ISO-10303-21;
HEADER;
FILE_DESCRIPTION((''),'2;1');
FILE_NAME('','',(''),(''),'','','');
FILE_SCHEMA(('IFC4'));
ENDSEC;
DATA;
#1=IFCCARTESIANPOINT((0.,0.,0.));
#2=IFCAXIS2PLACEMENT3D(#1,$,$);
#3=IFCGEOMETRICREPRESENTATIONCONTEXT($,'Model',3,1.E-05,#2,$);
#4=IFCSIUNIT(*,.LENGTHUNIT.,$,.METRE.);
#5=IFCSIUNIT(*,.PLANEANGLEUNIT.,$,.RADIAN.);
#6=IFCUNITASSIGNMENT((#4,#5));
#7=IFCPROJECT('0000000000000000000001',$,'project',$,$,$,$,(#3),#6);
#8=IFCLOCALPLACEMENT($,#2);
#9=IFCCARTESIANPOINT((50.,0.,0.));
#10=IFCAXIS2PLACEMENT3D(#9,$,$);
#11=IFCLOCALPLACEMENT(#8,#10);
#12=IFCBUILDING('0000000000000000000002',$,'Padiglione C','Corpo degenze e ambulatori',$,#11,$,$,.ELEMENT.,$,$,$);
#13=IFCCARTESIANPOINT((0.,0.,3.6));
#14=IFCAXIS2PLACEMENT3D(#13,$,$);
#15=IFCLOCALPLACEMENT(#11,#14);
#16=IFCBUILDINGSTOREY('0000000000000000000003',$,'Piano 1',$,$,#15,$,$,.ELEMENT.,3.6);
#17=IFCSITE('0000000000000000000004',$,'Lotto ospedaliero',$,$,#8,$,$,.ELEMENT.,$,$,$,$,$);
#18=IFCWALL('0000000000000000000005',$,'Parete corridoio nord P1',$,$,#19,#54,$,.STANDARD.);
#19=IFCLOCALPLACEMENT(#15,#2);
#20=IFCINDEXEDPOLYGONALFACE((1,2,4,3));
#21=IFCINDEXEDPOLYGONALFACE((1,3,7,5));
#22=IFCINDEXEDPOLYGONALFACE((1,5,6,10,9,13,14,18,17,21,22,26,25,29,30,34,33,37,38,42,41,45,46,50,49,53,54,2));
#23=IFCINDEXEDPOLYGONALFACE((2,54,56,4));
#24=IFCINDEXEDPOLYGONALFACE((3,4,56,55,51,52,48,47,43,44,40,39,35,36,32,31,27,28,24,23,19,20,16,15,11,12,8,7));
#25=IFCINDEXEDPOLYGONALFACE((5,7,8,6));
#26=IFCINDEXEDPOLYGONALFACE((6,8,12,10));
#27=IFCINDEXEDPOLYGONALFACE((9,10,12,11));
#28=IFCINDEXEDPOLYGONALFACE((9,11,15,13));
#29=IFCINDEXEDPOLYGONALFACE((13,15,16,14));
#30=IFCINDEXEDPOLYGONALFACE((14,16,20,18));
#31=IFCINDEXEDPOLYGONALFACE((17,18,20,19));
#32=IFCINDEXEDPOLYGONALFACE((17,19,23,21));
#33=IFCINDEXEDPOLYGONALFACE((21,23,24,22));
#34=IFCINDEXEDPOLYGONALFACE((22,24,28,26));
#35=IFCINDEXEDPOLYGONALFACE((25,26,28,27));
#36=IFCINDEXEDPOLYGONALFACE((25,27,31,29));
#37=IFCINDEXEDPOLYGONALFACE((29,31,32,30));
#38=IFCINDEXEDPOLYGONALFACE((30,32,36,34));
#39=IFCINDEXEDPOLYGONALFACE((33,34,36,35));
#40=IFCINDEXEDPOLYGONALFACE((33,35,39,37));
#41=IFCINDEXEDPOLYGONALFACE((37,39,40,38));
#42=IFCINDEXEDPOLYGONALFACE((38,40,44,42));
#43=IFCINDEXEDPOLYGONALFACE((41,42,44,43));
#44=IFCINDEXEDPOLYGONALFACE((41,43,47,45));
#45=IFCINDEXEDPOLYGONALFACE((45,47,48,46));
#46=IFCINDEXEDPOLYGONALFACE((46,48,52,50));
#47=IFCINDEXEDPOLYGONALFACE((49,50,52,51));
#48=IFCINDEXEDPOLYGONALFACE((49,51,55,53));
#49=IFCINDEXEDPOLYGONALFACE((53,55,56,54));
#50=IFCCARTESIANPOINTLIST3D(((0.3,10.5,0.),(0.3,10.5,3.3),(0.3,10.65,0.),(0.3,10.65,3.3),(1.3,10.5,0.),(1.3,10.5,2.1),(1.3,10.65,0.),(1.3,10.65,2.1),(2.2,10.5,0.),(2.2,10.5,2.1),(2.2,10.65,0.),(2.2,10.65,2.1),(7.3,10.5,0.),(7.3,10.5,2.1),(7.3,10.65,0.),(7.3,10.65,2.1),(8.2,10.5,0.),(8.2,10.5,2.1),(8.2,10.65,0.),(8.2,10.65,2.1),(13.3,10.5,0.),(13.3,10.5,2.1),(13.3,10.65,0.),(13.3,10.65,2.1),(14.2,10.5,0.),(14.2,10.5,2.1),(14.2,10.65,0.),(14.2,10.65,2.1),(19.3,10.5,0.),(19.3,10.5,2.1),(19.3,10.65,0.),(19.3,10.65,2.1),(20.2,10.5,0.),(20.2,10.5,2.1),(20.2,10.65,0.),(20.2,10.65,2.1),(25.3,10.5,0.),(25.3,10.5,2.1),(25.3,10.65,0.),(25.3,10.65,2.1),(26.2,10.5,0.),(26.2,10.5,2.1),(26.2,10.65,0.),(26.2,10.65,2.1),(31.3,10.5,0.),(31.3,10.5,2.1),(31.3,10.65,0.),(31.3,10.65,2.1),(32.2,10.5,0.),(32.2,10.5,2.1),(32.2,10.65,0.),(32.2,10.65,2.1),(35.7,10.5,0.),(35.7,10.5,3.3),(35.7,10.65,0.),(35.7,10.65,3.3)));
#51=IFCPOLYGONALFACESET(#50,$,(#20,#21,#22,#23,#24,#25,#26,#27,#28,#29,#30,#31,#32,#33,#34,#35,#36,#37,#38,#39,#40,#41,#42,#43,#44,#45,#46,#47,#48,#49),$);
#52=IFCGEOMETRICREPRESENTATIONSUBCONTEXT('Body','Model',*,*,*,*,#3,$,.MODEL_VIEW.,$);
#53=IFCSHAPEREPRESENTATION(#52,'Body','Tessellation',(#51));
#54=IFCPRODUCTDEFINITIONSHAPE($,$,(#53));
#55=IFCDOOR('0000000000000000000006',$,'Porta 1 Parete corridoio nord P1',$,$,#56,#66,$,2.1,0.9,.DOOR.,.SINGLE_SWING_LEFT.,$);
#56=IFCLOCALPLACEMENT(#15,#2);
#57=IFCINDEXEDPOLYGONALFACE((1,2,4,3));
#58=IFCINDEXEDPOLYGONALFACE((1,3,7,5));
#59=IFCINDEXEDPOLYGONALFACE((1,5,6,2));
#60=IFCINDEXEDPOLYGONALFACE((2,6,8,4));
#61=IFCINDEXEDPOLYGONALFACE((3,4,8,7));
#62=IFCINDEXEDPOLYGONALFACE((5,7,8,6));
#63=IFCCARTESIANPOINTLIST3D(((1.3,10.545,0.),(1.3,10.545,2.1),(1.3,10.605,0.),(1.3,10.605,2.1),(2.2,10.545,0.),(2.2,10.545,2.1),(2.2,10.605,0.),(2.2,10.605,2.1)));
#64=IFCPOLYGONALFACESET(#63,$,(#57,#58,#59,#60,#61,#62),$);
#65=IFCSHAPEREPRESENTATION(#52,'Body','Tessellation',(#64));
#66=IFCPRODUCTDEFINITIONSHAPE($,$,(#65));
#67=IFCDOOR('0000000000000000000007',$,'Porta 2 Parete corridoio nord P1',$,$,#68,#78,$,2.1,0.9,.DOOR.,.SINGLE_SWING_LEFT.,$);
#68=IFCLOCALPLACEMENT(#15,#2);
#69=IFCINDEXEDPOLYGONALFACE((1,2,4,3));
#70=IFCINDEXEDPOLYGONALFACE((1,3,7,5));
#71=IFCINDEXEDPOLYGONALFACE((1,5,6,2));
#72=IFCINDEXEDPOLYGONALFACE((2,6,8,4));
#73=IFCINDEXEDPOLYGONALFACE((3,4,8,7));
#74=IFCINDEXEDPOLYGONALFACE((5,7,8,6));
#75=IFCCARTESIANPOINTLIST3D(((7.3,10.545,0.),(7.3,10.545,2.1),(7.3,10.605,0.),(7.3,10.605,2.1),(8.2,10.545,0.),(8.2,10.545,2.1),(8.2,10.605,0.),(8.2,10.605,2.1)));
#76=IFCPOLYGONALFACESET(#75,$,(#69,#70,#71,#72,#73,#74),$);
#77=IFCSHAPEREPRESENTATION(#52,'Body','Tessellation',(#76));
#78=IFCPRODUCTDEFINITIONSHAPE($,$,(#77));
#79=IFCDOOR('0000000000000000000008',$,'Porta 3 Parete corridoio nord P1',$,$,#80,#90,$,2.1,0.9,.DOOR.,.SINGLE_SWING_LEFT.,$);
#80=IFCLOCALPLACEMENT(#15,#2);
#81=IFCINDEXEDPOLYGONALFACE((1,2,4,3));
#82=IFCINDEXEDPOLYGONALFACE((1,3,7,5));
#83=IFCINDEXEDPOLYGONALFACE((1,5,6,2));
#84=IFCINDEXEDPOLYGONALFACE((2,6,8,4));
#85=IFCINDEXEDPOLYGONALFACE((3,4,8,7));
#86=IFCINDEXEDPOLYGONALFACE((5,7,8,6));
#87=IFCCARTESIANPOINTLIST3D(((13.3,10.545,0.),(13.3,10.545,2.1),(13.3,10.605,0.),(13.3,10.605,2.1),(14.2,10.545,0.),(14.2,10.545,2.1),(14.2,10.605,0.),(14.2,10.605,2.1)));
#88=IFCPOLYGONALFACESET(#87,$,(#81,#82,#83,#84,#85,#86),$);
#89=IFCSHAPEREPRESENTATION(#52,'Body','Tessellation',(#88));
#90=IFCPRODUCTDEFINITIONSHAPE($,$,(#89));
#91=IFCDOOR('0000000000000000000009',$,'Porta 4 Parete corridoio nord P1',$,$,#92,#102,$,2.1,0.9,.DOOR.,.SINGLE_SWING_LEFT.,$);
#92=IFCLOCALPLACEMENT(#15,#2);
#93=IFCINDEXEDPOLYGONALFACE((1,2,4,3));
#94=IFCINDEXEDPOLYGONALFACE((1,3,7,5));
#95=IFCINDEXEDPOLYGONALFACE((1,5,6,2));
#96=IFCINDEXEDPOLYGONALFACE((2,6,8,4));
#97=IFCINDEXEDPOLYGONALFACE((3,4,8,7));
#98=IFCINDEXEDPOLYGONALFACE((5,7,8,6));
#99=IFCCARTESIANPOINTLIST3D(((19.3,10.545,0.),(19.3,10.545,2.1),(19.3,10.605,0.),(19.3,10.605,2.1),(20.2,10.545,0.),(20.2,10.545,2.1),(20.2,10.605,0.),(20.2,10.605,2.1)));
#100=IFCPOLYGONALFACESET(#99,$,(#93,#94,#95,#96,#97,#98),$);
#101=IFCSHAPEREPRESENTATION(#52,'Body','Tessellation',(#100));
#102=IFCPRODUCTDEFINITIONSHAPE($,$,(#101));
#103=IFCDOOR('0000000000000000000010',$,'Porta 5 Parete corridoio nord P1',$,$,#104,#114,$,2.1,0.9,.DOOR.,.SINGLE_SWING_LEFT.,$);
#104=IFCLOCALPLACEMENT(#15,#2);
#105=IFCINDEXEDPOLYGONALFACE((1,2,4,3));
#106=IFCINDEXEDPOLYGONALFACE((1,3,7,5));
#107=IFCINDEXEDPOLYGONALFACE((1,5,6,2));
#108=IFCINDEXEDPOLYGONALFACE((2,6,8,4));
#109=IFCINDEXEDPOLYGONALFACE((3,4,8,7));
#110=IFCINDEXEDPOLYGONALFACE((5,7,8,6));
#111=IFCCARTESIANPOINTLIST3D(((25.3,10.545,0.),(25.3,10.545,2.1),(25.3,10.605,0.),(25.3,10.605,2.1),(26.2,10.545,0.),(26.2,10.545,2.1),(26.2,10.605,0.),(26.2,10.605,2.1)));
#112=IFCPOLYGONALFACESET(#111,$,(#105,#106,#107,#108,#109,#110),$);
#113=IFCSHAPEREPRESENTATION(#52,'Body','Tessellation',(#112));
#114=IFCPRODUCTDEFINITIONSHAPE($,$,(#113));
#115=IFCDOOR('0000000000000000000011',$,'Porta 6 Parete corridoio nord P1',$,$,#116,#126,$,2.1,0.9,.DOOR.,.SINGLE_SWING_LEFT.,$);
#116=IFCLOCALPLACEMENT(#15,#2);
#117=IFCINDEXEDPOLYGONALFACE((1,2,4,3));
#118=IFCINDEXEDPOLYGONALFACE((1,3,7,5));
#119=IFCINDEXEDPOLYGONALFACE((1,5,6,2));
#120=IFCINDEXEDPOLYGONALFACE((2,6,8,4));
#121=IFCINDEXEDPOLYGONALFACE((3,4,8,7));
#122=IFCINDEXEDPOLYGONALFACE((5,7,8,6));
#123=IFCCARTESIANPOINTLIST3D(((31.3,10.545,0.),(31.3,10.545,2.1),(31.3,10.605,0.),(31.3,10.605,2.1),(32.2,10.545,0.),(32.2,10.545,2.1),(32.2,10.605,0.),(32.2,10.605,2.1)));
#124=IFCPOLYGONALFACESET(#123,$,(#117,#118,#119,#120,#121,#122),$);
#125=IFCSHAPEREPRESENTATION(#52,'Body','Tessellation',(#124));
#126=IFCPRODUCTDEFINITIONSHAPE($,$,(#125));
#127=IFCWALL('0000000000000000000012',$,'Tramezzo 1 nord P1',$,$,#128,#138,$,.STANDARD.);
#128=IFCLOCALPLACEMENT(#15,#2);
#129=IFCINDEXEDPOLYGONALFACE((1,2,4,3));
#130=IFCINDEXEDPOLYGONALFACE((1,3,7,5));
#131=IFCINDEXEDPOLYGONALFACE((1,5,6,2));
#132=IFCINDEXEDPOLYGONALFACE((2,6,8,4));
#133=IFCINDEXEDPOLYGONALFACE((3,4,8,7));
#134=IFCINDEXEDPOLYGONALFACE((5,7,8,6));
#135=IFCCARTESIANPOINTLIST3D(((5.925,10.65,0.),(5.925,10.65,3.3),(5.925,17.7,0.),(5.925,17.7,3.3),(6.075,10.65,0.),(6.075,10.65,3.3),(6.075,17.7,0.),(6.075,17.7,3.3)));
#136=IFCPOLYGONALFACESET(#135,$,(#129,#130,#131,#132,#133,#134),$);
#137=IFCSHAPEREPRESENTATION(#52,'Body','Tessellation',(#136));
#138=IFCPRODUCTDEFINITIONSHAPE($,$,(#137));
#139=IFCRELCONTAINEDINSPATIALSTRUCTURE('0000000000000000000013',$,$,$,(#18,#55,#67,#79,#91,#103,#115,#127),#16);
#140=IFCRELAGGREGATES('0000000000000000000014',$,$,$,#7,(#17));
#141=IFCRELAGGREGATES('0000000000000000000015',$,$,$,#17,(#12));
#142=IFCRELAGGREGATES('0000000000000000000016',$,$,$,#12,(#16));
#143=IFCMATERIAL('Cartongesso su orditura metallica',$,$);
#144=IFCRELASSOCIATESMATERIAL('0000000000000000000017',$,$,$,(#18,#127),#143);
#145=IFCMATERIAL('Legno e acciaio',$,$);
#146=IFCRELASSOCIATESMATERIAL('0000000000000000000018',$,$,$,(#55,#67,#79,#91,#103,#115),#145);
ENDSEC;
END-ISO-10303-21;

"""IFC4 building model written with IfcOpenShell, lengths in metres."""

from ifc_helpers import new_model, si_unit, frame, frame_2d, origin, place, context, subcontext, project, spatial, rectangle, extrude, material, element, fill, save


model = new_model("IFC4")

# Units and contexts
model_context = context("Model", 3, precision=1e-05, world=origin())
body_context = subcontext(model_context, "Body", "Model", "MODEL_VIEW")
ifc_project = project(units=[si_unit("LENGTHUNIT", "METRE"), si_unit("PLANEANGLEUNIT", "RADIAN")], contexts=[model_context])

# Site, building, storey
site_placement = place(None, origin())
site = spatial("IfcSite", under=ifc_project, at=site_placement, Name="Lotto ospedaliero", CompositionType="ELEMENT")
building_placement = place(site_placement, frame((50.0, 0.0, 0.0)))
building = spatial("IfcBuilding", under=site, at=building_placement, Name="Padiglione C", Description="Corpo degenze e ambulatori", CompositionType="ELEMENT")
storey_placement = place(building_placement, frame((0.0, 0.0, 3.6)))
storey = spatial("IfcBuildingStorey", under=building, at=storey_placement, Name="Piano 1", CompositionType="ELEMENT", Elevation=3.6)

# Wall, openings, doors
ifc_material_1 = material(Name="Cartongesso su orditura metallica")
ifc_material_2 = material(Name="Legno e acciaio")
wall_1_placement = place(storey_placement, frame((0.3, 10.5, 0.0)))
wall_1 = element("IfcWall", 1, at=wall_1_placement, inside=storey, material=ifc_material_1, Name="Parete corridoio nord P1", PredefinedType="STANDARD", context=body_context, shape_type="SweptSolid", body=[
    extrude(rectangle(XDim=35.4, YDim=0.15, at=frame_2d((17.7, 0.075))), origin(), (0.0, 0.0, 1.0), 3.3),
])
opening_1_placement = place(wall_1_placement, frame((1.0, -0.1, 0.0)))
opening_1 = element("IfcOpeningElement", 2, at=opening_1_placement, cuts=wall_1, PredefinedType="OPENING", context=body_context, shape_type="SweptSolid", body=[
    extrude(rectangle(XDim=0.9, YDim=0.35, at=frame_2d((0.45, 0.175))), origin(), (0.0, 0.0, 1.0), 2.1),
])
opening_2_placement = place(wall_1_placement, frame((7.0, -0.1, 0.0)))
opening_2 = element("IfcOpeningElement", 3, at=opening_2_placement, cuts=wall_1, PredefinedType="OPENING", context=body_context, shape_type="SweptSolid", body=[
    extrude(rectangle(XDim=0.9, YDim=0.35, at=frame_2d((0.45, 0.175))), origin(), (0.0, 0.0, 1.0), 2.1),
])
opening_3_placement = place(wall_1_placement, frame((13.0, -0.1, 0.0)))
opening_3 = element("IfcOpeningElement", 4, at=opening_3_placement, cuts=wall_1, PredefinedType="OPENING", context=body_context, shape_type="SweptSolid", body=[
    extrude(rectangle(XDim=0.9, YDim=0.35, at=frame_2d((0.45, 0.175))), origin(), (0.0, 0.0, 1.0), 2.1),
])
opening_4_placement = place(wall_1_placement, frame((19.0, -0.1, 0.0)))
opening_4 = element("IfcOpeningElement", 5, at=opening_4_placement, cuts=wall_1, PredefinedType="OPENING", context=body_context, shape_type="SweptSolid", body=[
    extrude(rectangle(XDim=0.9, YDim=0.35, at=frame_2d((0.45, 0.175))), origin(), (0.0, 0.0, 1.0), 2.1),
])
opening_5_placement = place(wall_1_placement, frame((25.0, -0.1, 0.0)))
opening_5 = element("IfcOpeningElement", 6, at=opening_5_placement, cuts=wall_1, PredefinedType="OPENING", context=body_context, shape_type="SweptSolid", body=[
    extrude(rectangle(XDim=0.9, YDim=0.35, at=frame_2d((0.45, 0.175))), origin(), (0.0, 0.0, 1.0), 2.1),
])
opening_6_placement = place(wall_1_placement, frame((31.0, -0.1, 0.0)))
opening_6 = element("IfcOpeningElement", 7, at=opening_6_placement, cuts=wall_1, PredefinedType="OPENING", context=body_context, shape_type="SweptSolid", body=[
    extrude(rectangle(XDim=0.9, YDim=0.35, at=frame_2d((0.45, 0.175))), origin(), (0.0, 0.0, 1.0), 2.1),
])
door_1_placement = place(wall_1_placement, frame((1.0, 0.045, 0.0)))
door_1 = element("IfcDoor", 8, at=door_1_placement, inside=storey, material=ifc_material_2, Name="Porta 1 Parete corridoio nord P1", OperationType="SINGLE_SWING_LEFT", OverallHeight=2.1, OverallWidth=0.9, PredefinedType="DOOR", context=body_context, shape_type="SweptSolid", body=[
    extrude(rectangle(XDim=0.9, YDim=0.06, at=frame_2d((0.45, 0.03))), origin(), (0.0, 0.0, 1.0), 2.1),
])
fill(opening_1, door_1)
door_2_placement = place(wall_1_placement, frame((7.0, 0.045, 0.0)))
door_2 = element("IfcDoor", 9, at=door_2_placement, inside=storey, material=ifc_material_2, Name="Porta 2 Parete corridoio nord P1", OperationType="SINGLE_SWING_LEFT", OverallHeight=2.1, OverallWidth=0.9, PredefinedType="DOOR", context=body_context, shape_type="SweptSolid", body=[
    extrude(rectangle(XDim=0.9, YDim=0.06, at=frame_2d((0.45, 0.03))), origin(), (0.0, 0.0, 1.0), 2.1),
])
fill(opening_2, door_2)
door_3_placement = place(wall_1_placement, frame((13.0, 0.045, 0.0)))
door_3 = element("IfcDoor", 10, at=door_3_placement, inside=storey, material=ifc_material_2, Name="Porta 3 Parete corridoio nord P1", OperationType="SINGLE_SWING_LEFT", OverallHeight=2.1, OverallWidth=0.9, PredefinedType="DOOR", context=body_context, shape_type="SweptSolid", body=[
    extrude(rectangle(XDim=0.9, YDim=0.06, at=frame_2d((0.45, 0.03))), origin(), (0.0, 0.0, 1.0), 2.1),
])
fill(opening_3, door_3)
door_4_placement = place(wall_1_placement, frame((19.0, 0.045, 0.0)))
door_4 = element("IfcDoor", 11, at=door_4_placement, inside=storey, material=ifc_material_2, Name="Porta 4 Parete corridoio nord P1", OperationType="SINGLE_SWING_LEFT", OverallHeight=2.1, OverallWidth=0.9, PredefinedType="DOOR", context=body_context, shape_type="SweptSolid", body=[
    extrude(rectangle(XDim=0.9, YDim=0.06, at=frame_2d((0.45, 0.03))), origin(), (0.0, 0.0, 1.0), 2.1),
])
fill(opening_4, door_4)
door_5_placement = place(wall_1_placement, frame((25.0, 0.045, 0.0)))
door_5 = element("IfcDoor", 12, at=door_5_placement, inside=storey, material=ifc_material_2, Name="Porta 5 Parete corridoio nord P1", OperationType="SINGLE_SWING_LEFT", OverallHeight=2.1, OverallWidth=0.9, PredefinedType="DOOR", context=body_context, shape_type="SweptSolid", body=[
    extrude(rectangle(XDim=0.9, YDim=0.06, at=frame_2d((0.45, 0.03))), origin(), (0.0, 0.0, 1.0), 2.1),
])
fill(opening_5, door_5)
door_6_placement = place(wall_1_placement, frame((31.0, 0.045, 0.0)))
door_6 = element("IfcDoor", 13, at=door_6_placement, inside=storey, material=ifc_material_2, Name="Porta 6 Parete corridoio nord P1", OperationType="SINGLE_SWING_LEFT", OverallHeight=2.1, OverallWidth=0.9, PredefinedType="DOOR", context=body_context, shape_type="SweptSolid", body=[
    extrude(rectangle(XDim=0.9, YDim=0.06, at=frame_2d((0.45, 0.03))), origin(), (0.0, 0.0, 1.0), 2.1),
])
fill(opening_6, door_6)

# Wall
wall_2_placement = place(storey_placement, frame((5.925, 10.65, 0.0)))
element("IfcWall", 14, at=wall_2_placement, inside=storey, material=ifc_material_1, Name="Tramezzo 1 nord P1", PredefinedType="STANDARD", context=body_context, shape_type="SweptSolid", body=[
    extrude(rectangle(XDim=0.15, YDim=7.05, at=frame_2d((0.075, 3.525))), origin(), (0.0, 0.0, 1.0), 3.3),
])

save(model, "model.ifc")
